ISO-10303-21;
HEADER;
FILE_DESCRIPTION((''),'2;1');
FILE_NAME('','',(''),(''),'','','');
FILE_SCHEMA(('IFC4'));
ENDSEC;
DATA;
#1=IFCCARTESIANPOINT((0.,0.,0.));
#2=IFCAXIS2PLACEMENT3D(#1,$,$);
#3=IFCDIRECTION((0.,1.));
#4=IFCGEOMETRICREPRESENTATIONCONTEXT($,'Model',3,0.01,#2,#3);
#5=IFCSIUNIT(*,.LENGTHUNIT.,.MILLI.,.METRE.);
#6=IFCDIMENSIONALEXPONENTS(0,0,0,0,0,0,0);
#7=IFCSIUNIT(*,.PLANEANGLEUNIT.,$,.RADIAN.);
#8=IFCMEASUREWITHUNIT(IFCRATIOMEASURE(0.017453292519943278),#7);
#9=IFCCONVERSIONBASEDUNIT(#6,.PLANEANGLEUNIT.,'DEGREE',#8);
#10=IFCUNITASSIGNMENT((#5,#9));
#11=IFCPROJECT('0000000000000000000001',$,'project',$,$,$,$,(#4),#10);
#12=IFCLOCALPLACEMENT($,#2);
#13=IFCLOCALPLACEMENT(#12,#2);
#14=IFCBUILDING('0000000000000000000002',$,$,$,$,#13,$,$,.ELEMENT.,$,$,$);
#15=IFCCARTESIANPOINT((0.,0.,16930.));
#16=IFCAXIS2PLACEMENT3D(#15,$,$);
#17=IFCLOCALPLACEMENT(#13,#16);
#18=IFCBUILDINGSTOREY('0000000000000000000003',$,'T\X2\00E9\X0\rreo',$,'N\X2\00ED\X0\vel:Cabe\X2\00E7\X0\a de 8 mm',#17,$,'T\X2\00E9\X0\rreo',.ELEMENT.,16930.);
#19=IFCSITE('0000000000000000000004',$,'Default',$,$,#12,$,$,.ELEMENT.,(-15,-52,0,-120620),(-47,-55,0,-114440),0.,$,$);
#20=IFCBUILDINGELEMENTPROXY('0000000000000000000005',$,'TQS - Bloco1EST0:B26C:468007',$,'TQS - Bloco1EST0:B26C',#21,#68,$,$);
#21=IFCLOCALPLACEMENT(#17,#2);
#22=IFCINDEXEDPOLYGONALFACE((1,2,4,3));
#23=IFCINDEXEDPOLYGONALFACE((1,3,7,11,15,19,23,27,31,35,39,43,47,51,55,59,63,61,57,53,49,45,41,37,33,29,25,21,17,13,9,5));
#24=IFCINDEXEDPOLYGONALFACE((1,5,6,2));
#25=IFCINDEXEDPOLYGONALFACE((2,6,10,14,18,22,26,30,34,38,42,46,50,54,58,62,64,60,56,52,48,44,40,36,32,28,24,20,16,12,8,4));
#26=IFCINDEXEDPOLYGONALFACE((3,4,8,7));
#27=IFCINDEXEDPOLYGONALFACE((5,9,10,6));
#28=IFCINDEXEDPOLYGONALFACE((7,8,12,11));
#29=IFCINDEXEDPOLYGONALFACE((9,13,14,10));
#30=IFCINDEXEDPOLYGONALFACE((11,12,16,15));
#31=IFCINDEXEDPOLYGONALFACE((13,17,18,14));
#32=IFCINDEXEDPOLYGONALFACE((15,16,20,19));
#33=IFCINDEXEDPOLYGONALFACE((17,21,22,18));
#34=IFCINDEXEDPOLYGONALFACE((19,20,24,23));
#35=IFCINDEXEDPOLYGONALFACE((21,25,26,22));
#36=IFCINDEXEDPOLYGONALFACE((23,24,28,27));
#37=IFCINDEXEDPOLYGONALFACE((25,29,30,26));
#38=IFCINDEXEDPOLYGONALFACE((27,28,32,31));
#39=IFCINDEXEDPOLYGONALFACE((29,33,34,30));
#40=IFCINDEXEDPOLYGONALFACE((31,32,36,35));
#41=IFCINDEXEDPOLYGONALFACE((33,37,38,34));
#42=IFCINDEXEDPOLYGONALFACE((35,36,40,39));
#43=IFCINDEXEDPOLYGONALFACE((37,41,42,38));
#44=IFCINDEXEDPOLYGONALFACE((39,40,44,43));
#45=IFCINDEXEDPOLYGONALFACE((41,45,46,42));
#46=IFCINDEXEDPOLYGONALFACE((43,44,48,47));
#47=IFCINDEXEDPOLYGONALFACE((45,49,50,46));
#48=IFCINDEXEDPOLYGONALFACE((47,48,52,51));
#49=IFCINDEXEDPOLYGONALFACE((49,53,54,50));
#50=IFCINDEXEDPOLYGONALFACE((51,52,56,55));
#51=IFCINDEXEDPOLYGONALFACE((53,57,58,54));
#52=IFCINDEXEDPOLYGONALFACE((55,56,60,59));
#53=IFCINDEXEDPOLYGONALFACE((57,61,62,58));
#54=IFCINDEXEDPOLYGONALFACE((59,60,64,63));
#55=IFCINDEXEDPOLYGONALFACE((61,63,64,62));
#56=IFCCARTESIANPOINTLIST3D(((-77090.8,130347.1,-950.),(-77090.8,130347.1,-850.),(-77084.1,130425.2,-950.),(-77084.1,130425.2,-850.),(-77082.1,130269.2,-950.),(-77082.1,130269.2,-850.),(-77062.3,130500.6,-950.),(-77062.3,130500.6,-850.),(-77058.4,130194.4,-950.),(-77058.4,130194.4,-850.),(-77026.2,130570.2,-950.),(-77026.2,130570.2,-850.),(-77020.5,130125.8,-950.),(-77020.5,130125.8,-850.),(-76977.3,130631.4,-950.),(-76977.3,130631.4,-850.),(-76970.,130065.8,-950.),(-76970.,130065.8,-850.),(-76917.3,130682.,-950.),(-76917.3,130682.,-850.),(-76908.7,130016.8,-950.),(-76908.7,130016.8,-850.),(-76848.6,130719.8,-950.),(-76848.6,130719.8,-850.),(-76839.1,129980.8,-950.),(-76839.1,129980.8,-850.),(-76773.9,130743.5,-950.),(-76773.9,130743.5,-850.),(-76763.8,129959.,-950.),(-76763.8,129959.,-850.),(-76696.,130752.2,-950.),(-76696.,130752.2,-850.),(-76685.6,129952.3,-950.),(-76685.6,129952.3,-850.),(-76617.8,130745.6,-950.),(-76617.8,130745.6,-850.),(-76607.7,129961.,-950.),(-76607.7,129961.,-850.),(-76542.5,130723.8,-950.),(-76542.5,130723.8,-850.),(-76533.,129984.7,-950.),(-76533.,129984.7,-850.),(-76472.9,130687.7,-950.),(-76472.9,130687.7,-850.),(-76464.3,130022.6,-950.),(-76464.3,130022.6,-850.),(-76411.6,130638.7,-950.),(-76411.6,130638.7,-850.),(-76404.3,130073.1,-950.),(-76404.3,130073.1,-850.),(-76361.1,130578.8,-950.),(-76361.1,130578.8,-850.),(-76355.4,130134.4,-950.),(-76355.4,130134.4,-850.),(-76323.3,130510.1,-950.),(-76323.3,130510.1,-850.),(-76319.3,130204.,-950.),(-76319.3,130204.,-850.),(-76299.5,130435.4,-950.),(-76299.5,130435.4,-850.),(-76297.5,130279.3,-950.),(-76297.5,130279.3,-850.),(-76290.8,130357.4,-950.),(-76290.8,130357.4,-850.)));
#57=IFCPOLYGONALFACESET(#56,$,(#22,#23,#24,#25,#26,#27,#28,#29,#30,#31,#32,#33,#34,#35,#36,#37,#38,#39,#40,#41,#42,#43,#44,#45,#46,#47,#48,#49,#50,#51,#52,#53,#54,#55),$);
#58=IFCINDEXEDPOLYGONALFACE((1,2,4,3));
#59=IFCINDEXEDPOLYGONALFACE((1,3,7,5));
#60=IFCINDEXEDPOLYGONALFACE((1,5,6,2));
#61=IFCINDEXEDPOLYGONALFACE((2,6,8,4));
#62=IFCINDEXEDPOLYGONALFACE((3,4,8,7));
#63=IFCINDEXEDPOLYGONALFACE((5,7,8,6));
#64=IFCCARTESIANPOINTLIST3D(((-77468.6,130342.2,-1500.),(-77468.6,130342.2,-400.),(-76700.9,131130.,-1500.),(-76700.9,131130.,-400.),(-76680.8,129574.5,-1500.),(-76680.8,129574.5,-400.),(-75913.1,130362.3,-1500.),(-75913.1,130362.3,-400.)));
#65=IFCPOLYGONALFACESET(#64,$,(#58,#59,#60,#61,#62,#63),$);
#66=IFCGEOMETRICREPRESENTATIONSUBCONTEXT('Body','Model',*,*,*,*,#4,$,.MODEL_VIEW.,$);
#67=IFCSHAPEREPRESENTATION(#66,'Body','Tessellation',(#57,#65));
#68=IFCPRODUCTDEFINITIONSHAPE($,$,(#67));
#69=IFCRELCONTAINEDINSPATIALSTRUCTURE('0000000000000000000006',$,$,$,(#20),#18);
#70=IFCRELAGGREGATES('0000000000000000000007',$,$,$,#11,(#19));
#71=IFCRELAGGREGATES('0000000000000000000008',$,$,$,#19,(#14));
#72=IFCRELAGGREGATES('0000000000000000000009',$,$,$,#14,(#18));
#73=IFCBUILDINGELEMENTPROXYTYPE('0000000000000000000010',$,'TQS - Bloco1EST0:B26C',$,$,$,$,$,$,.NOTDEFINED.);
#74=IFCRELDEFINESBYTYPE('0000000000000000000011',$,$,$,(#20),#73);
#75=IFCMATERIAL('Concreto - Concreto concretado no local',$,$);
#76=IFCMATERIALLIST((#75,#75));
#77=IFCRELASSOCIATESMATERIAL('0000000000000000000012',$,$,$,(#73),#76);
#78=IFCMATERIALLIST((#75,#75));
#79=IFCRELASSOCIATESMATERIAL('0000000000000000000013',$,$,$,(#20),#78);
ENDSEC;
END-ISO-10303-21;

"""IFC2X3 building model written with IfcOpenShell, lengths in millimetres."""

from ifc_helpers import new_model, entity, si_unit, converted_unit, direction, frame, frame_2d, origin, origin_2d_with_axis, place, context, subcontext, project, spatial, rectangle, circle, extrude, source, transform, mapped, material, material_list, type_object, type_shapes, element, save


model = new_model("IFC2X3")

# Units and contexts
model_context = context("Model", 3, precision=0.01, world=origin(), true_north=direction((0.0, 1.0)))
body_context = subcontext(model_context, "Body", "Model", "MODEL_VIEW")
ifc_project = project(units=[si_unit("LENGTHUNIT", "METRE", prefix="MILLI"), converted_unit("PLANEANGLEUNIT", "DEGREE", entity("IfcRatioMeasure", 0.017453292519943278), si_unit("PLANEANGLEUNIT", "RADIAN"), dimensions=[0, 0, 0, 0, 0, 0, 0])], contexts=[model_context])

# Site, building, storey
site_placement = place(None, origin())
site = spatial("IfcSite", under=ifc_project, at=site_placement, Name="Default", CompositionType="ELEMENT", RefLatitude=(-15, -52, 0, -120620), RefLongitude=(-47, -55, 0, -114440), RefElevation=0.0)
building_placement = place(site_placement, origin())
building = spatial("IfcBuilding", under=site, at=building_placement, CompositionType="ELEMENT")
storey_placement = place(building_placement, frame((0.0, 0.0, 16930.0)))
storey = spatial("IfcBuildingStorey", under=building, at=storey_placement, Name="Térreo", ObjectType="Nível:Cabeça de 8 mm", LongName="Térreo", CompositionType="ELEMENT", Elevation=16930.0)

# Building element proxy
ifc_material_1 = material(Name="Concreto - Concreto concretado no local")
ifc_material_list_1 = material_list([ifc_material_1, ifc_material_1])
ifc_material_list_2 = material_list([ifc_material_1, ifc_material_1])
building_element_proxy_type_1 = type_object("IfcBuildingElementProxyType", Name="TQS - Bloco1EST0:B26C", PredefinedType="NOTDEFINED", material=ifc_material_list_2)
shared_shape_1 = source(origin(), body_context, "Body", "SweptSolid", [
    extrude(circle(Radius=400.0, at=frame_2d((0.0, 0.0), x_axis=(1.0, 0.0))), frame((0.0, 0.0, -550.0)), (0.0, 0.0, 1.0), 100.0),
    extrude(rectangle(XDim=1100.0, YDim=1100.0, at=origin_2d_with_axis()), frame((0.0, 0.0, -1100.0), z_axis=(0.0, 0.0, 1.0), x_axis=(-1.0, 0.0, 0.0)), (0.0, 0.0, 1.0), 1100.0),
])
type_shapes(building_element_proxy_type_1, [shared_shape_1])
proxy_1_placement = place(storey_placement, frame((-76690.8, 130352.3, -400.0), z_axis=(0.0, 0.0, 1.0), x_axis=(0.697915, 0.71618, 0.0)))
element("IfcBuildingElementProxy", 1, at=proxy_1_placement, inside=storey, type_object=building_element_proxy_type_1, material=ifc_material_list_1, Name="TQS - Bloco1EST0:B26C:468007", ObjectType="TQS - Bloco1EST0:B26C", context=body_context, shape_type="MappedRepresentation", body=[
    mapped(shared_shape_1, transform((0.0, 0.0, 0.0), scale=1.0)),
])

save(model, "model.ifc")
